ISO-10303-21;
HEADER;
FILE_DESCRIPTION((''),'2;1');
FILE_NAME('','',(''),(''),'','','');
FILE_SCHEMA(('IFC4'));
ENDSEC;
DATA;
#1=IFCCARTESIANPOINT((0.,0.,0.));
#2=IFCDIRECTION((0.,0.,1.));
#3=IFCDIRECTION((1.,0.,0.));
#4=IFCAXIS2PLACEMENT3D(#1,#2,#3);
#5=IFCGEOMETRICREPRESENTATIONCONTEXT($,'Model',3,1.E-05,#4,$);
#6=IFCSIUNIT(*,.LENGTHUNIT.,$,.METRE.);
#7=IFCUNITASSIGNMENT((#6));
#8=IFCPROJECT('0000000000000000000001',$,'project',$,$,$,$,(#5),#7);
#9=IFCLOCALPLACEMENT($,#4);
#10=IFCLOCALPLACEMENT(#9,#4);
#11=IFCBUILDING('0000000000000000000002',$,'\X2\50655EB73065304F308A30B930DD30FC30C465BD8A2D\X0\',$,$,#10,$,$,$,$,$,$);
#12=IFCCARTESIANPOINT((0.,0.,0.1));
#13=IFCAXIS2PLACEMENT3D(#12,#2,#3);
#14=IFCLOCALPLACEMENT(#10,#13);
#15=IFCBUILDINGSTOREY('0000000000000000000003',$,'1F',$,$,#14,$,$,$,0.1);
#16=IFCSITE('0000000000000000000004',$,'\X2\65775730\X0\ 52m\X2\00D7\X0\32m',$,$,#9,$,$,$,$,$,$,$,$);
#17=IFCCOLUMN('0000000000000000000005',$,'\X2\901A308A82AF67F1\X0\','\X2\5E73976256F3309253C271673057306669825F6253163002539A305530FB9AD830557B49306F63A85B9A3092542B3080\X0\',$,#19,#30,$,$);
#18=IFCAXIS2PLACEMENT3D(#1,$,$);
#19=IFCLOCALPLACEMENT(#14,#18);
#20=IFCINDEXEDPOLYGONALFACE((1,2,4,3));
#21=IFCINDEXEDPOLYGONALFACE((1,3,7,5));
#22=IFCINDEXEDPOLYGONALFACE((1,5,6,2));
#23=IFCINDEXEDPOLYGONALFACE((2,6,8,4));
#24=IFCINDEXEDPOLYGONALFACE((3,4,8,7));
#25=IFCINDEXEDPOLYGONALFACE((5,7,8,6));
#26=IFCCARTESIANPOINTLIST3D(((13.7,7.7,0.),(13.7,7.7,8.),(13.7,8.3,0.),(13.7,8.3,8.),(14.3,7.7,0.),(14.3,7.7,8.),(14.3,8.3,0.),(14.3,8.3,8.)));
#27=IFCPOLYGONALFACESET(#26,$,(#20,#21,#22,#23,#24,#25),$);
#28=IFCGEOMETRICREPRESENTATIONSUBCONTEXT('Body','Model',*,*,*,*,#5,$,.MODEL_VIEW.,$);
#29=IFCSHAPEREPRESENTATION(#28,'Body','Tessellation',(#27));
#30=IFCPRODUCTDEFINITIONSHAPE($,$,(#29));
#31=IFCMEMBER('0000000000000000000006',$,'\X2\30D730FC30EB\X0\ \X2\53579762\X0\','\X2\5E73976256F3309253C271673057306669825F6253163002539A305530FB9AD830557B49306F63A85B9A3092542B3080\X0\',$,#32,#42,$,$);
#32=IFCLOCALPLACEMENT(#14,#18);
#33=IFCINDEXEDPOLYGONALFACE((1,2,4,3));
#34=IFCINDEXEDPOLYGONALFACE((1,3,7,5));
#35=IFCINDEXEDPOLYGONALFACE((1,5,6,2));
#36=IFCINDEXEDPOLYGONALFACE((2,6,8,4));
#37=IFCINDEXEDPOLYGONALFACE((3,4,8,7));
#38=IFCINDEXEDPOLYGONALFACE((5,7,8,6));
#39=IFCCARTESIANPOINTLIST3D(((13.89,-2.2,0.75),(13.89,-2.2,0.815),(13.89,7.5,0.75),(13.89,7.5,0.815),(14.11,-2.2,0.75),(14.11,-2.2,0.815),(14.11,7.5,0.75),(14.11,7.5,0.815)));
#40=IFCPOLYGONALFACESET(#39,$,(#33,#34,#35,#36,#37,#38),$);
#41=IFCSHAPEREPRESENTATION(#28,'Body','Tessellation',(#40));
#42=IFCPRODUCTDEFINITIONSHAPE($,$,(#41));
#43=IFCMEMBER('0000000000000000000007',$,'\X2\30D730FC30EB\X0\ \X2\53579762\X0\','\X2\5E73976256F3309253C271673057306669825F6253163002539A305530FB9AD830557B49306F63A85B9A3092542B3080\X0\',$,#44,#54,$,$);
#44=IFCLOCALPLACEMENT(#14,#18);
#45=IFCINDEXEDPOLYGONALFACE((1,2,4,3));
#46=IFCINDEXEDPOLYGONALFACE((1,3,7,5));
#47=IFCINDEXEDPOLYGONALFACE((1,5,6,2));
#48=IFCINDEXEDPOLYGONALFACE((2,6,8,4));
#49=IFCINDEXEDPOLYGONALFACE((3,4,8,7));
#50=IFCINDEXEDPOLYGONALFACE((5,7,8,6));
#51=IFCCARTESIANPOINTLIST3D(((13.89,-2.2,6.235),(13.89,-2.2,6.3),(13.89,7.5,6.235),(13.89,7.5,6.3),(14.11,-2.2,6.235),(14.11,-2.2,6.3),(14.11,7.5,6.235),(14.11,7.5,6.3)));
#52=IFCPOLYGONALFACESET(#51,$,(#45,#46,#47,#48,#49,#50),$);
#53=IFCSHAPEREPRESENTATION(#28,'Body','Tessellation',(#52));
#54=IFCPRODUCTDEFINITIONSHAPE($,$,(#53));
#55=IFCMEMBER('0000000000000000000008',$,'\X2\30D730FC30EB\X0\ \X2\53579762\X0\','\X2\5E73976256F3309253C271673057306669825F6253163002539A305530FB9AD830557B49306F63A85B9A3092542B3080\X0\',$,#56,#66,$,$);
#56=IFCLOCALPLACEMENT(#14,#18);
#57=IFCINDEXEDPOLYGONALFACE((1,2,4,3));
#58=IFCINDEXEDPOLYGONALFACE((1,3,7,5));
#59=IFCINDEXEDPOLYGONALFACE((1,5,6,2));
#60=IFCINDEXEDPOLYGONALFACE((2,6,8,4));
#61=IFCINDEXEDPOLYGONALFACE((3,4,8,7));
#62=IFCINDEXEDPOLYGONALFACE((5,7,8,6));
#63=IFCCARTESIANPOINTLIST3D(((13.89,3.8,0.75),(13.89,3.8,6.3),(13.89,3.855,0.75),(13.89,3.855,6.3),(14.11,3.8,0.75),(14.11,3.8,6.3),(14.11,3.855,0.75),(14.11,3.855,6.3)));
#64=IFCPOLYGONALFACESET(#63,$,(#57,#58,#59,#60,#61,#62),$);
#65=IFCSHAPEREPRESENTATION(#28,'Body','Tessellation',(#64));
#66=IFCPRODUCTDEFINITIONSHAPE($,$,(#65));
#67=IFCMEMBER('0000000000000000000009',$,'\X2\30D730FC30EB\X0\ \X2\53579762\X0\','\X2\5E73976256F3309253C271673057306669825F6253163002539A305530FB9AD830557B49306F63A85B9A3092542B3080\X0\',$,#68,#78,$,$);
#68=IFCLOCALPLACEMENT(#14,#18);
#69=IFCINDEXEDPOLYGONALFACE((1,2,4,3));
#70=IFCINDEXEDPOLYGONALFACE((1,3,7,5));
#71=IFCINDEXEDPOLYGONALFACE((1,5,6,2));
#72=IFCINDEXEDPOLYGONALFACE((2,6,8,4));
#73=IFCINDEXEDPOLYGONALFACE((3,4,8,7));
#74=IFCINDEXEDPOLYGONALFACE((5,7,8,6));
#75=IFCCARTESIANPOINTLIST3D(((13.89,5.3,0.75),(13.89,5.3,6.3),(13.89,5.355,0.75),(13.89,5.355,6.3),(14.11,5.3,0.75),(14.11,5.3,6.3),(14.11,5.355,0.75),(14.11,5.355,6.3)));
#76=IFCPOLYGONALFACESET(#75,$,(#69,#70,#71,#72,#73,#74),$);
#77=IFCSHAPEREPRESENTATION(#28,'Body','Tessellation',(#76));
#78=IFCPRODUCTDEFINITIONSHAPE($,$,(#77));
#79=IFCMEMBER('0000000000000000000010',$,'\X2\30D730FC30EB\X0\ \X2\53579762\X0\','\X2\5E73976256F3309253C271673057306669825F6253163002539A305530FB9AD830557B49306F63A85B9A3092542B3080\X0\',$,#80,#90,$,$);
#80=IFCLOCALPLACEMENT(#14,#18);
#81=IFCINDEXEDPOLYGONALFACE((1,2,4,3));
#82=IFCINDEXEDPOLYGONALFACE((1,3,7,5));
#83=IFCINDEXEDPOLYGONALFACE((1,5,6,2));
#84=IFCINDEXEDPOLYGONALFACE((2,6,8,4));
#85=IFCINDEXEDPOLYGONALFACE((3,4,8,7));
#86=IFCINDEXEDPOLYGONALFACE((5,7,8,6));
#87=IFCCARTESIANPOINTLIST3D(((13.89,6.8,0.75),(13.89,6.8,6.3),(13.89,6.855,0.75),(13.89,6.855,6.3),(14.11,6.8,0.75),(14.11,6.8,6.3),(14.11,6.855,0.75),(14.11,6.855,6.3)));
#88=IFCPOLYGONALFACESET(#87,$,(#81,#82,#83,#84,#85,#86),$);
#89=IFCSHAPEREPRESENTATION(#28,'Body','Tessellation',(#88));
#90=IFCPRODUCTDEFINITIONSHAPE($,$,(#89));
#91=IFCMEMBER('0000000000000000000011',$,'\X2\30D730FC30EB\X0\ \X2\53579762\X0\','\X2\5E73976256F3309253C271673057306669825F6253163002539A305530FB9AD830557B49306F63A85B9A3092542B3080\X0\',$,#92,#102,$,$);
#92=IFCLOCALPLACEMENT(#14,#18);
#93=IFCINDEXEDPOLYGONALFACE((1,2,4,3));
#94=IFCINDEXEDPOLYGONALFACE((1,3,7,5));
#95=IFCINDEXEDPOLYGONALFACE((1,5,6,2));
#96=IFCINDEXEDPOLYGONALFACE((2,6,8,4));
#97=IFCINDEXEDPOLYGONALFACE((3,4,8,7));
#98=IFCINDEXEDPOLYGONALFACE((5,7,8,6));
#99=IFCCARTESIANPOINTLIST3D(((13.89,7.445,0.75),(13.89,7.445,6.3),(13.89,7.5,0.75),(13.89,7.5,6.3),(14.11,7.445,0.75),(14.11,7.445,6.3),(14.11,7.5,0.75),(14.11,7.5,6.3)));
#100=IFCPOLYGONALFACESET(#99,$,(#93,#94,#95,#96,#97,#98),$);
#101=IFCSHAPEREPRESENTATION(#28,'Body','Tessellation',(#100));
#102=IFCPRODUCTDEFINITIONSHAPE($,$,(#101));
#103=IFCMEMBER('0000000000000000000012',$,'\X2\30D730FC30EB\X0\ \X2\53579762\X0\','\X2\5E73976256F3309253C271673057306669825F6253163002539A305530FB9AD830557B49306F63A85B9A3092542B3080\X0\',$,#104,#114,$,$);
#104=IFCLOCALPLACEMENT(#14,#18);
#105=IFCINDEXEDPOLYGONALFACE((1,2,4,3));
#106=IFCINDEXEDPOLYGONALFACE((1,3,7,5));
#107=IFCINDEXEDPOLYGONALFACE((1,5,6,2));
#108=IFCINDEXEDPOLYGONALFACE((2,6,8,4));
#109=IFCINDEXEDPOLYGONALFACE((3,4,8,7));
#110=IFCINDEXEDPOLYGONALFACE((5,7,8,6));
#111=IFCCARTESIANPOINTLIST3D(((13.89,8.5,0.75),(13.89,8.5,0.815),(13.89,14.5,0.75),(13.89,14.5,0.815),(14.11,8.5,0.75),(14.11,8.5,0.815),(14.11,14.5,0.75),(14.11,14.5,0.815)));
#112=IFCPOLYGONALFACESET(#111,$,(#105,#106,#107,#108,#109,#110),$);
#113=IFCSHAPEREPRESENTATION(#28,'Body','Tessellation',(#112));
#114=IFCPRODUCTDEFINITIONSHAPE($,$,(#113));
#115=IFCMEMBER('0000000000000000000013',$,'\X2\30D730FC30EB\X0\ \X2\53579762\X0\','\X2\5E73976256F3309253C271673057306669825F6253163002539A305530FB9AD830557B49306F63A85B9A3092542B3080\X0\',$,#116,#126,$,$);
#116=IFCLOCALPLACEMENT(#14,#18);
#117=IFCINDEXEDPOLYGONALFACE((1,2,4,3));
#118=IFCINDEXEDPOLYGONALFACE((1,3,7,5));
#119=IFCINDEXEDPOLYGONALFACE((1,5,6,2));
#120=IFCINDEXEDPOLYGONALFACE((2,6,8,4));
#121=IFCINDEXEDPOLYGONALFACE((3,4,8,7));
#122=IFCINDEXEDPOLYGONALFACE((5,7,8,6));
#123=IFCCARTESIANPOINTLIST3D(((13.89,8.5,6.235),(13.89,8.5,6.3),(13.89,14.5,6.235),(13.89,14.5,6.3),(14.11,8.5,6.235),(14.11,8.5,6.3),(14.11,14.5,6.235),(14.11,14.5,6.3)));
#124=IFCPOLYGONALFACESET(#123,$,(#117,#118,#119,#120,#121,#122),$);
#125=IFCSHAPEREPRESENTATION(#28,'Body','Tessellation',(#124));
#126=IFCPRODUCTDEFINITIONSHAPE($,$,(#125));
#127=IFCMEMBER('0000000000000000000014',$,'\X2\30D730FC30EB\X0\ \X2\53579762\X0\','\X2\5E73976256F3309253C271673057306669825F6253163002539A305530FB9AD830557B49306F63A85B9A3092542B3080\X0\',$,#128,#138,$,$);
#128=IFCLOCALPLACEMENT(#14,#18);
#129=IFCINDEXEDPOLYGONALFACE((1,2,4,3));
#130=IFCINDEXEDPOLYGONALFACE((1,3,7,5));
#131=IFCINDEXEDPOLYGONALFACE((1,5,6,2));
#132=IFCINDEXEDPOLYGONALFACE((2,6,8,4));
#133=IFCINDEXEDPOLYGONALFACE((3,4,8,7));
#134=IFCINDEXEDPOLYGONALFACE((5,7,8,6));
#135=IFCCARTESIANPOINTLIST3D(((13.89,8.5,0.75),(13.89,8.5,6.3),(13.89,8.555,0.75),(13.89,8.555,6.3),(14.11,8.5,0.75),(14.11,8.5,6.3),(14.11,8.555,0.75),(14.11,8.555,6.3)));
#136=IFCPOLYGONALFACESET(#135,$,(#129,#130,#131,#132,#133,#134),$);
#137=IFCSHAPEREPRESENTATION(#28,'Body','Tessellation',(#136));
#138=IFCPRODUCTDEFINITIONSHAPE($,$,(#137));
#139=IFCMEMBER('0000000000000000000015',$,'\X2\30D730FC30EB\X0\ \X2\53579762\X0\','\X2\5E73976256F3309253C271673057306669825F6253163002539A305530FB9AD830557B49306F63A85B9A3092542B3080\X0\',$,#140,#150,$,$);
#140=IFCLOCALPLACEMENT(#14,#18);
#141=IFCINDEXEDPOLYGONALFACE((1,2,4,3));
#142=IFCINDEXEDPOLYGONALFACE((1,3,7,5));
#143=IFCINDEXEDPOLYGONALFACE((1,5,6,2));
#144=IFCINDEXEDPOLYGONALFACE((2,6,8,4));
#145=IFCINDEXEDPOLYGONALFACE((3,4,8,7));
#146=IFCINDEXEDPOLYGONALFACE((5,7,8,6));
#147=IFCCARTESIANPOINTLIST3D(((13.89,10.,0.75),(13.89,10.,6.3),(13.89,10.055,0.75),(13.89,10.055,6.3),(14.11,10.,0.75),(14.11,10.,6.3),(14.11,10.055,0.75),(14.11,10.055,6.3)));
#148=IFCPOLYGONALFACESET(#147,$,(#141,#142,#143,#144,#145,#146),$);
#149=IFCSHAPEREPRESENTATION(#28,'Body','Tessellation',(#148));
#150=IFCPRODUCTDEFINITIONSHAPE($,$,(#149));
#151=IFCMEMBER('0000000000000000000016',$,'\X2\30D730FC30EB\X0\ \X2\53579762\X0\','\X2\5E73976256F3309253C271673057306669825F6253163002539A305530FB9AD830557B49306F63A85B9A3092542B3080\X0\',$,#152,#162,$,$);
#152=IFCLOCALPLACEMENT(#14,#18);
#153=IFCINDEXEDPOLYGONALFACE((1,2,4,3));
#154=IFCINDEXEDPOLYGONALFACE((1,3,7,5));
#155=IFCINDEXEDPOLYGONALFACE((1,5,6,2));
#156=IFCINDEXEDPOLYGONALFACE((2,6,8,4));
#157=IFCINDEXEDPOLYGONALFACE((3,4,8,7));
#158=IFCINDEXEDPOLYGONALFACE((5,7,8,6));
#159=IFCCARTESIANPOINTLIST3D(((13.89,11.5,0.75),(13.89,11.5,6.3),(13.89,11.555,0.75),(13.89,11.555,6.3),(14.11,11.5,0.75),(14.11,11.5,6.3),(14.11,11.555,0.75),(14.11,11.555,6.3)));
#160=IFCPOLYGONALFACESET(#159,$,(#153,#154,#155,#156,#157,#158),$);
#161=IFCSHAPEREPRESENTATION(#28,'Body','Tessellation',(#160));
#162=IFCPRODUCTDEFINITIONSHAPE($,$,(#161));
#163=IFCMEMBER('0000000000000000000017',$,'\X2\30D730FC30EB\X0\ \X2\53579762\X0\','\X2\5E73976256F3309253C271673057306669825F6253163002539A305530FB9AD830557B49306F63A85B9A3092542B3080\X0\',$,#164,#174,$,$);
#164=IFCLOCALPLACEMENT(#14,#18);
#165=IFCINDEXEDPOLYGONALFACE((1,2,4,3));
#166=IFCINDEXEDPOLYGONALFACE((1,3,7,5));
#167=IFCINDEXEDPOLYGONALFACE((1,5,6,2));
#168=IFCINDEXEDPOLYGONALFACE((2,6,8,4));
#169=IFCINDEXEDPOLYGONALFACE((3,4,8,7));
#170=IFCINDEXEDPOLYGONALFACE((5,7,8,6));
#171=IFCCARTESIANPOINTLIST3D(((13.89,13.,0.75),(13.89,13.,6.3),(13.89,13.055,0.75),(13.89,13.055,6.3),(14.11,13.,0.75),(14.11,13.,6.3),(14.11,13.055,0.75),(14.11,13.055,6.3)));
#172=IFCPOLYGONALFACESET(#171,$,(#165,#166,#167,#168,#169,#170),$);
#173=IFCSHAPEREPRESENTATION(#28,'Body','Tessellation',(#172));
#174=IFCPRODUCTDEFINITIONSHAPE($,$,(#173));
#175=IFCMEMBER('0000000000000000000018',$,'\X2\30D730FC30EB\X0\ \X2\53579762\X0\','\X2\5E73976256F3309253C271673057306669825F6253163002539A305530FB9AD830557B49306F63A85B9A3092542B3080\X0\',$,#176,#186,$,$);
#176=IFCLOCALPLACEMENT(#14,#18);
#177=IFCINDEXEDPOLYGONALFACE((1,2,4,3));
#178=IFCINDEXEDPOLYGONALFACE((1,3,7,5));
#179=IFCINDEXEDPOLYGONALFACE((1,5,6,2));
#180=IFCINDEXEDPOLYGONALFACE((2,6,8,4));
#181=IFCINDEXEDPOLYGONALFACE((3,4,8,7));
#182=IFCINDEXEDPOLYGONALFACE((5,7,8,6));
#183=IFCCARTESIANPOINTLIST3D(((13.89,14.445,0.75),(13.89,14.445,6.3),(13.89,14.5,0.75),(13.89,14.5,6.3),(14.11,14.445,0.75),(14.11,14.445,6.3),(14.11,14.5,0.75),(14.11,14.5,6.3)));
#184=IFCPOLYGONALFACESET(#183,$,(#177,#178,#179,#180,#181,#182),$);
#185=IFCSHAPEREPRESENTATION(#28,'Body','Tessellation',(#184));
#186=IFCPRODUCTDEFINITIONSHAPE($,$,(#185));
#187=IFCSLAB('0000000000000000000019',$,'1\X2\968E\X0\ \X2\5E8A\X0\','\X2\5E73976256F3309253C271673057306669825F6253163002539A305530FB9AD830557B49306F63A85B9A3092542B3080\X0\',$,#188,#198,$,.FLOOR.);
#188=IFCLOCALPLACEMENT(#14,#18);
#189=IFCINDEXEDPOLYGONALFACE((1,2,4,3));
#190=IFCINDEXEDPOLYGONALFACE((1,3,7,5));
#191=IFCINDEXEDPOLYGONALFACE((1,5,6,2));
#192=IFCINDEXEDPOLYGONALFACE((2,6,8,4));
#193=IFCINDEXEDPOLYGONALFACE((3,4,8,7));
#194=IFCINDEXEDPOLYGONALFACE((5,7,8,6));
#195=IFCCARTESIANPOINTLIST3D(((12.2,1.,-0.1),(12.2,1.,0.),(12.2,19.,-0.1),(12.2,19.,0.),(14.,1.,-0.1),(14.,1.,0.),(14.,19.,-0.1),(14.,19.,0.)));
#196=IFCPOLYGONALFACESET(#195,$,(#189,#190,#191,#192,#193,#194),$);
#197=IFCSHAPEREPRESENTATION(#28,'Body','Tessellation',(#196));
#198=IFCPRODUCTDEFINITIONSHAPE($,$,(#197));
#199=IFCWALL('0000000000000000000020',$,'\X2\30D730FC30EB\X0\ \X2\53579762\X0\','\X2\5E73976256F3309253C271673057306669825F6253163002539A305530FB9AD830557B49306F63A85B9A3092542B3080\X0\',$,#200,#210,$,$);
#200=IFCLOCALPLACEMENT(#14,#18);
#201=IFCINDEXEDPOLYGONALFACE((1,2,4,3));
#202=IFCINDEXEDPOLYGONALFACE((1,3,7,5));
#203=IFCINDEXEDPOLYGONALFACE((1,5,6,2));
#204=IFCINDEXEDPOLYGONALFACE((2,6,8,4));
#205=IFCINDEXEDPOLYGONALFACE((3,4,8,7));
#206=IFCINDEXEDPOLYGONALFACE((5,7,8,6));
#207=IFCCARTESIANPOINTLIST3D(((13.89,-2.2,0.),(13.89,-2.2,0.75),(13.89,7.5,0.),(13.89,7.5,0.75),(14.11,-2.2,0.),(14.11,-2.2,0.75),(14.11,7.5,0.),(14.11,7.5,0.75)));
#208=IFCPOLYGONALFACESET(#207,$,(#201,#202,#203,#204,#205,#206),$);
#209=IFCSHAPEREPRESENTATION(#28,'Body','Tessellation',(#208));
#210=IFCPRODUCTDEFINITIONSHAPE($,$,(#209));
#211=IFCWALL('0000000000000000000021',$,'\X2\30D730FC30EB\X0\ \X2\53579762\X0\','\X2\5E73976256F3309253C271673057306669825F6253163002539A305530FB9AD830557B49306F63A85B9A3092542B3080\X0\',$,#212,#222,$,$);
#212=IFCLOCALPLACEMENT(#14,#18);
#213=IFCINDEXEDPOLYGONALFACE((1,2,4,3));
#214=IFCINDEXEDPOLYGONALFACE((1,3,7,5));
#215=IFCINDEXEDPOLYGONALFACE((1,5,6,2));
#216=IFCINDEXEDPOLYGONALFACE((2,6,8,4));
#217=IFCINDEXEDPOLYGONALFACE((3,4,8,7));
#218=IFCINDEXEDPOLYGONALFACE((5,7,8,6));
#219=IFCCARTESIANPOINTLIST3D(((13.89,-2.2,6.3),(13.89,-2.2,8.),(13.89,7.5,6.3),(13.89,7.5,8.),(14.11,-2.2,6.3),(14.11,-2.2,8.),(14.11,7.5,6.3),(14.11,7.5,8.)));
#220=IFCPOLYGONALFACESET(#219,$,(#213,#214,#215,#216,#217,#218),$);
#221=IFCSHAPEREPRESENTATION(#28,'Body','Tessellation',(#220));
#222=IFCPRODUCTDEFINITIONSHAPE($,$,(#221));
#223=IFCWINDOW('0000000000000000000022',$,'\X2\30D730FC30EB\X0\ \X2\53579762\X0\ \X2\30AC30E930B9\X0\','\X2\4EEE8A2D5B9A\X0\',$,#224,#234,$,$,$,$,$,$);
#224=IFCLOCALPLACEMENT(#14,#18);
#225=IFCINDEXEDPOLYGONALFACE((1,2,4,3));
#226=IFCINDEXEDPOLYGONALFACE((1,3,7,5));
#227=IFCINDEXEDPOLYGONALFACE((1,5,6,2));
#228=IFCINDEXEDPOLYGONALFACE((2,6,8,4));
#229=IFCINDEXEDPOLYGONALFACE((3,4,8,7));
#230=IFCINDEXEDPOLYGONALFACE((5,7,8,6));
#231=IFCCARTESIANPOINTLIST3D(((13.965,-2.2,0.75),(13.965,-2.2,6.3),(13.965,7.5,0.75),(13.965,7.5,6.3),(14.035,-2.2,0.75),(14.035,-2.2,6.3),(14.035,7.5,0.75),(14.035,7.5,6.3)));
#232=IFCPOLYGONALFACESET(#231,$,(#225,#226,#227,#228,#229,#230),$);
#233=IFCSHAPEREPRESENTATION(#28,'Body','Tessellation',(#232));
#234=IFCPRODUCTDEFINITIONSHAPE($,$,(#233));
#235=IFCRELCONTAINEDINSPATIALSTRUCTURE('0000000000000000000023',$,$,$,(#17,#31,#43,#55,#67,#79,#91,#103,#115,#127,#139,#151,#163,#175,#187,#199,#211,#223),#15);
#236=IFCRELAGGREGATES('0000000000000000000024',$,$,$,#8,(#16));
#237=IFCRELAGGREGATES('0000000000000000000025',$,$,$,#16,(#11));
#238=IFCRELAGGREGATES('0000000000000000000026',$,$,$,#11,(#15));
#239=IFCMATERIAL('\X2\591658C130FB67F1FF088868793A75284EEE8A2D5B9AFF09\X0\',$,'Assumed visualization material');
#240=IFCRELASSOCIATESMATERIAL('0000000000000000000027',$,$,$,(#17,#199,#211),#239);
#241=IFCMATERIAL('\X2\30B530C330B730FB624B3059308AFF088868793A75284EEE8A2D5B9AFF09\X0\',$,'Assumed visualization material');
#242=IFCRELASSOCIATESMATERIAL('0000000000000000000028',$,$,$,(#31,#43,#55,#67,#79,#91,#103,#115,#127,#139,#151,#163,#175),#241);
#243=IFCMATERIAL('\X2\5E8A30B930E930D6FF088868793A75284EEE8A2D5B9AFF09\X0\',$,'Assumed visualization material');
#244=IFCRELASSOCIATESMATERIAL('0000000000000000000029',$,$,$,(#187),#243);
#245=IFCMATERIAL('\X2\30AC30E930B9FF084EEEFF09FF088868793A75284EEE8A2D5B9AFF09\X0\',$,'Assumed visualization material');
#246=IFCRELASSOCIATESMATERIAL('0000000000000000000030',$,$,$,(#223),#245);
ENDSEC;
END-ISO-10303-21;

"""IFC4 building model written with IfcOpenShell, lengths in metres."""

from ifc_helpers import new_model, si_unit, frame, origin_with_axes, place, context, subcontext, project, spatial, rectangle, extrude, material, element, save


model = new_model("IFC4")

# Units and contexts
model_context = context("Model", 3, precision=1e-05, world=origin_with_axes())
body_context = subcontext(model_context, "Body", "Model", "MODEL_VIEW")
ifc_project = project(units=[si_unit("LENGTHUNIT", "METRE")], contexts=[model_context])

# Site, building, storey
site_placement = place(None, origin_with_axes())
site = spatial("IfcSite", under=ifc_project, at=site_placement, Name="敷地 52m×32m")
building_placement = place(site_placement, origin_with_axes())
building = spatial("IfcBuilding", under=site, at=building_placement, Name="健康づくりスポーツ施設")
storey_placement = place(building_placement, frame((0.0, 0.0, 0.1), z_axis=(0.0, 0.0, 1.0), x_axis=(1.0, 0.0, 0.0)))
storey = spatial("IfcBuildingStorey", under=building, at=storey_placement, Name="1F", Elevation=0.1)

# Column
ifc_material_1 = material(Name="外壁・柱（表示用仮設定）", Category="Assumed visualization material")
column_placement = place(storey_placement, frame((14.0, 8.0, 0.0), z_axis=(0.0, 0.0, 1.0), x_axis=(1.0, 0.0, 0.0)))
element("IfcColumn", 1, at=column_placement, inside=storey, material=ifc_material_1, Name="通り芯柱", Description="平面図を参照して概形化。厚さ・高さ等は推定を含む", context=body_context, shape_type="SweptSolid", body=[
    extrude(rectangle(XDim=0.6, YDim=0.6), origin_with_axes(), (0.0, 0.0, 1.0), 8.0),
])

# Members
ifc_material_2 = material(Name="サッシ・手すり（表示用仮設定）", Category="Assumed visualization material")
member_1_placement = place(storey_placement, frame((14.0, 2.65, 0.75), z_axis=(0.0, 0.0, 1.0), x_axis=(1.0, 0.0, 0.0)))
element("IfcMember", 2, at=member_1_placement, inside=storey, material=ifc_material_2, Name="プール 南面", Description="平面図を参照して概形化。厚さ・高さ等は推定を含む", context=body_context, shape_type="SweptSolid", body=[
    extrude(rectangle(XDim=0.22, YDim=9.7), origin_with_axes(), (0.0, 0.0, 1.0), 0.065),
])
member_2_placement = place(storey_placement, frame((14.0, 2.65, 6.235), z_axis=(0.0, 0.0, 1.0), x_axis=(1.0, 0.0, 0.0)))
element("IfcMember", 3, at=member_2_placement, inside=storey, material=ifc_material_2, Name="プール 南面", Description="平面図を参照して概形化。厚さ・高さ等は推定を含む", context=body_context, shape_type="SweptSolid", body=[
    extrude(rectangle(XDim=0.22, YDim=9.7), origin_with_axes(), (0.0, 0.0, 1.0), 0.065),
])
for number, where, z_axis, x_axis, name in (
    (4, (14.0, 3.8275, 0.75), (0.0, 0.0, 1.0), (1.0, 0.0, 0.0), "プール 南面"),
    (5, (14.0, 5.3275, 0.75), (0.0, 0.0, 1.0), (1.0, 0.0, 0.0), "プール 南面"),
    (6, (14.0, 6.8275, 0.75), (0.0, 0.0, 1.0), (1.0, 0.0, 0.0), "プール 南面"),
    (7, (14.0, 7.4725, 0.75), (0.0, 0.0, 1.0), (1.0, 0.0, 0.0), "プール 南面"),
):
    element("IfcMember", number, at=place(storey_placement, frame(where, z_axis=z_axis, x_axis=x_axis)), inside=storey, material=ifc_material_2, Name=name, Description="平面図を参照して概形化。厚さ・高さ等は推定を含む", context=body_context, shape_type="SweptSolid", body=[
        extrude(rectangle(XDim=0.22, YDim=0.055), origin_with_axes(), (0.0, 0.0, 1.0), 5.55),
    ])
member_3_placement = place(storey_placement, frame((14.0, 11.5, 0.75), z_axis=(0.0, 0.0, 1.0), x_axis=(1.0, 0.0, 0.0)))
element("IfcMember", 8, at=member_3_placement, inside=storey, material=ifc_material_2, Name="プール 南面", Description="平面図を参照して概形化。厚さ・高さ等は推定を含む", context=body_context, shape_type="SweptSolid", body=[
    extrude(rectangle(XDim=0.22, YDim=6.0), origin_with_axes(), (0.0, 0.0, 1.0), 0.065),
])
member_4_placement = place(storey_placement, frame((14.0, 11.5, 6.235), z_axis=(0.0, 0.0, 1.0), x_axis=(1.0, 0.0, 0.0)))
element("IfcMember", 9, at=member_4_placement, inside=storey, material=ifc_material_2, Name="プール 南面", Description="平面図を参照して概形化。厚さ・高さ等は推定を含む", context=body_context, shape_type="SweptSolid", body=[
    extrude(rectangle(XDim=0.22, YDim=6.0), origin_with_axes(), (0.0, 0.0, 1.0), 0.065),
])
for number, where, z_axis, x_axis, name in (
    (10, (14.0, 8.5275, 0.75), (0.0, 0.0, 1.0), (1.0, 0.0, 0.0), "プール 南面"),
    (11, (14.0, 10.0275, 0.75), (0.0, 0.0, 1.0), (1.0, 0.0, 0.0), "プール 南面"),
    (12, (14.0, 11.5275, 0.75), (0.0, 0.0, 1.0), (1.0, 0.0, 0.0), "プール 南面"),
    (13, (14.0, 13.0275, 0.75), (0.0, 0.0, 1.0), (1.0, 0.0, 0.0), "プール 南面"),
    (14, (14.0, 14.4725, 0.75), (0.0, 0.0, 1.0), (1.0, 0.0, 0.0), "プール 南面"),
):
    element("IfcMember", number, at=place(storey_placement, frame(where, z_axis=z_axis, x_axis=x_axis)), inside=storey, material=ifc_material_2, Name=name, Description="平面図を参照して概形化。厚さ・高さ等は推定を含む", context=body_context, shape_type="SweptSolid", body=[
        extrude(rectangle(XDim=0.22, YDim=0.055), origin_with_axes(), (0.0, 0.0, 1.0), 5.55),
    ])

# Slab
ifc_material_3 = material(Name="床スラブ（表示用仮設定）", Category="Assumed visualization material")
slab_placement = place(storey_placement, frame((13.1, 10.0, -0.1), z_axis=(0.0, 0.0, 1.0), x_axis=(1.0, 0.0, 0.0)))
element("IfcSlab", 15, at=slab_placement, inside=storey, material=ifc_material_3, Name="1階 床", Description="平面図を参照して概形化。厚さ・高さ等は推定を含む", PredefinedType="FLOOR", context=body_context, shape_type="SweptSolid", body=[
    extrude(rectangle(XDim=1.8, YDim=18.0), origin_with_axes(), (0.0, 0.0, 1.0), 0.1),
])

# Walls
wall_1_placement = place(storey_placement, frame((14.0, 2.65, 0.0), z_axis=(0.0, 0.0, 1.0), x_axis=(1.0, 0.0, 0.0)))
element("IfcWall", 16, at=wall_1_placement, inside=storey, material=ifc_material_1, Name="プール 南面", Description="平面図を参照して概形化。厚さ・高さ等は推定を含む", context=body_context, shape_type="SweptSolid", body=[
    extrude(rectangle(XDim=0.22, YDim=9.7), origin_with_axes(), (0.0, 0.0, 1.0), 0.75),
])
wall_2_placement = place(storey_placement, frame((14.0, 2.65, 6.3), z_axis=(0.0, 0.0, 1.0), x_axis=(1.0, 0.0, 0.0)))
element("IfcWall", 17, at=wall_2_placement, inside=storey, material=ifc_material_1, Name="プール 南面", Description="平面図を参照して概形化。厚さ・高さ等は推定を含む", context=body_context, shape_type="SweptSolid", body=[
    extrude(rectangle(XDim=0.22, YDim=9.7), origin_with_axes(), (0.0, 0.0, 1.0), 1.7),
])

# Window
ifc_material_4 = material(Name="ガラス（仮）（表示用仮設定）", Category="Assumed visualization material")
window_1_placement = place(storey_placement, frame((14.0, 2.65, 0.75), z_axis=(0.0, 0.0, 1.0), x_axis=(1.0, 0.0, 0.0)))
element("IfcWindow", 18, at=window_1_placement, inside=storey, material=ifc_material_4, Name="プール 南面 ガラス", Description="仮設定", context=body_context, shape_type="SweptSolid", body=[
    extrude(rectangle(XDim=0.07, YDim=9.7), origin_with_axes(), (0.0, 0.0, 1.0), 5.55),
])

save(model, "model.ifc")
